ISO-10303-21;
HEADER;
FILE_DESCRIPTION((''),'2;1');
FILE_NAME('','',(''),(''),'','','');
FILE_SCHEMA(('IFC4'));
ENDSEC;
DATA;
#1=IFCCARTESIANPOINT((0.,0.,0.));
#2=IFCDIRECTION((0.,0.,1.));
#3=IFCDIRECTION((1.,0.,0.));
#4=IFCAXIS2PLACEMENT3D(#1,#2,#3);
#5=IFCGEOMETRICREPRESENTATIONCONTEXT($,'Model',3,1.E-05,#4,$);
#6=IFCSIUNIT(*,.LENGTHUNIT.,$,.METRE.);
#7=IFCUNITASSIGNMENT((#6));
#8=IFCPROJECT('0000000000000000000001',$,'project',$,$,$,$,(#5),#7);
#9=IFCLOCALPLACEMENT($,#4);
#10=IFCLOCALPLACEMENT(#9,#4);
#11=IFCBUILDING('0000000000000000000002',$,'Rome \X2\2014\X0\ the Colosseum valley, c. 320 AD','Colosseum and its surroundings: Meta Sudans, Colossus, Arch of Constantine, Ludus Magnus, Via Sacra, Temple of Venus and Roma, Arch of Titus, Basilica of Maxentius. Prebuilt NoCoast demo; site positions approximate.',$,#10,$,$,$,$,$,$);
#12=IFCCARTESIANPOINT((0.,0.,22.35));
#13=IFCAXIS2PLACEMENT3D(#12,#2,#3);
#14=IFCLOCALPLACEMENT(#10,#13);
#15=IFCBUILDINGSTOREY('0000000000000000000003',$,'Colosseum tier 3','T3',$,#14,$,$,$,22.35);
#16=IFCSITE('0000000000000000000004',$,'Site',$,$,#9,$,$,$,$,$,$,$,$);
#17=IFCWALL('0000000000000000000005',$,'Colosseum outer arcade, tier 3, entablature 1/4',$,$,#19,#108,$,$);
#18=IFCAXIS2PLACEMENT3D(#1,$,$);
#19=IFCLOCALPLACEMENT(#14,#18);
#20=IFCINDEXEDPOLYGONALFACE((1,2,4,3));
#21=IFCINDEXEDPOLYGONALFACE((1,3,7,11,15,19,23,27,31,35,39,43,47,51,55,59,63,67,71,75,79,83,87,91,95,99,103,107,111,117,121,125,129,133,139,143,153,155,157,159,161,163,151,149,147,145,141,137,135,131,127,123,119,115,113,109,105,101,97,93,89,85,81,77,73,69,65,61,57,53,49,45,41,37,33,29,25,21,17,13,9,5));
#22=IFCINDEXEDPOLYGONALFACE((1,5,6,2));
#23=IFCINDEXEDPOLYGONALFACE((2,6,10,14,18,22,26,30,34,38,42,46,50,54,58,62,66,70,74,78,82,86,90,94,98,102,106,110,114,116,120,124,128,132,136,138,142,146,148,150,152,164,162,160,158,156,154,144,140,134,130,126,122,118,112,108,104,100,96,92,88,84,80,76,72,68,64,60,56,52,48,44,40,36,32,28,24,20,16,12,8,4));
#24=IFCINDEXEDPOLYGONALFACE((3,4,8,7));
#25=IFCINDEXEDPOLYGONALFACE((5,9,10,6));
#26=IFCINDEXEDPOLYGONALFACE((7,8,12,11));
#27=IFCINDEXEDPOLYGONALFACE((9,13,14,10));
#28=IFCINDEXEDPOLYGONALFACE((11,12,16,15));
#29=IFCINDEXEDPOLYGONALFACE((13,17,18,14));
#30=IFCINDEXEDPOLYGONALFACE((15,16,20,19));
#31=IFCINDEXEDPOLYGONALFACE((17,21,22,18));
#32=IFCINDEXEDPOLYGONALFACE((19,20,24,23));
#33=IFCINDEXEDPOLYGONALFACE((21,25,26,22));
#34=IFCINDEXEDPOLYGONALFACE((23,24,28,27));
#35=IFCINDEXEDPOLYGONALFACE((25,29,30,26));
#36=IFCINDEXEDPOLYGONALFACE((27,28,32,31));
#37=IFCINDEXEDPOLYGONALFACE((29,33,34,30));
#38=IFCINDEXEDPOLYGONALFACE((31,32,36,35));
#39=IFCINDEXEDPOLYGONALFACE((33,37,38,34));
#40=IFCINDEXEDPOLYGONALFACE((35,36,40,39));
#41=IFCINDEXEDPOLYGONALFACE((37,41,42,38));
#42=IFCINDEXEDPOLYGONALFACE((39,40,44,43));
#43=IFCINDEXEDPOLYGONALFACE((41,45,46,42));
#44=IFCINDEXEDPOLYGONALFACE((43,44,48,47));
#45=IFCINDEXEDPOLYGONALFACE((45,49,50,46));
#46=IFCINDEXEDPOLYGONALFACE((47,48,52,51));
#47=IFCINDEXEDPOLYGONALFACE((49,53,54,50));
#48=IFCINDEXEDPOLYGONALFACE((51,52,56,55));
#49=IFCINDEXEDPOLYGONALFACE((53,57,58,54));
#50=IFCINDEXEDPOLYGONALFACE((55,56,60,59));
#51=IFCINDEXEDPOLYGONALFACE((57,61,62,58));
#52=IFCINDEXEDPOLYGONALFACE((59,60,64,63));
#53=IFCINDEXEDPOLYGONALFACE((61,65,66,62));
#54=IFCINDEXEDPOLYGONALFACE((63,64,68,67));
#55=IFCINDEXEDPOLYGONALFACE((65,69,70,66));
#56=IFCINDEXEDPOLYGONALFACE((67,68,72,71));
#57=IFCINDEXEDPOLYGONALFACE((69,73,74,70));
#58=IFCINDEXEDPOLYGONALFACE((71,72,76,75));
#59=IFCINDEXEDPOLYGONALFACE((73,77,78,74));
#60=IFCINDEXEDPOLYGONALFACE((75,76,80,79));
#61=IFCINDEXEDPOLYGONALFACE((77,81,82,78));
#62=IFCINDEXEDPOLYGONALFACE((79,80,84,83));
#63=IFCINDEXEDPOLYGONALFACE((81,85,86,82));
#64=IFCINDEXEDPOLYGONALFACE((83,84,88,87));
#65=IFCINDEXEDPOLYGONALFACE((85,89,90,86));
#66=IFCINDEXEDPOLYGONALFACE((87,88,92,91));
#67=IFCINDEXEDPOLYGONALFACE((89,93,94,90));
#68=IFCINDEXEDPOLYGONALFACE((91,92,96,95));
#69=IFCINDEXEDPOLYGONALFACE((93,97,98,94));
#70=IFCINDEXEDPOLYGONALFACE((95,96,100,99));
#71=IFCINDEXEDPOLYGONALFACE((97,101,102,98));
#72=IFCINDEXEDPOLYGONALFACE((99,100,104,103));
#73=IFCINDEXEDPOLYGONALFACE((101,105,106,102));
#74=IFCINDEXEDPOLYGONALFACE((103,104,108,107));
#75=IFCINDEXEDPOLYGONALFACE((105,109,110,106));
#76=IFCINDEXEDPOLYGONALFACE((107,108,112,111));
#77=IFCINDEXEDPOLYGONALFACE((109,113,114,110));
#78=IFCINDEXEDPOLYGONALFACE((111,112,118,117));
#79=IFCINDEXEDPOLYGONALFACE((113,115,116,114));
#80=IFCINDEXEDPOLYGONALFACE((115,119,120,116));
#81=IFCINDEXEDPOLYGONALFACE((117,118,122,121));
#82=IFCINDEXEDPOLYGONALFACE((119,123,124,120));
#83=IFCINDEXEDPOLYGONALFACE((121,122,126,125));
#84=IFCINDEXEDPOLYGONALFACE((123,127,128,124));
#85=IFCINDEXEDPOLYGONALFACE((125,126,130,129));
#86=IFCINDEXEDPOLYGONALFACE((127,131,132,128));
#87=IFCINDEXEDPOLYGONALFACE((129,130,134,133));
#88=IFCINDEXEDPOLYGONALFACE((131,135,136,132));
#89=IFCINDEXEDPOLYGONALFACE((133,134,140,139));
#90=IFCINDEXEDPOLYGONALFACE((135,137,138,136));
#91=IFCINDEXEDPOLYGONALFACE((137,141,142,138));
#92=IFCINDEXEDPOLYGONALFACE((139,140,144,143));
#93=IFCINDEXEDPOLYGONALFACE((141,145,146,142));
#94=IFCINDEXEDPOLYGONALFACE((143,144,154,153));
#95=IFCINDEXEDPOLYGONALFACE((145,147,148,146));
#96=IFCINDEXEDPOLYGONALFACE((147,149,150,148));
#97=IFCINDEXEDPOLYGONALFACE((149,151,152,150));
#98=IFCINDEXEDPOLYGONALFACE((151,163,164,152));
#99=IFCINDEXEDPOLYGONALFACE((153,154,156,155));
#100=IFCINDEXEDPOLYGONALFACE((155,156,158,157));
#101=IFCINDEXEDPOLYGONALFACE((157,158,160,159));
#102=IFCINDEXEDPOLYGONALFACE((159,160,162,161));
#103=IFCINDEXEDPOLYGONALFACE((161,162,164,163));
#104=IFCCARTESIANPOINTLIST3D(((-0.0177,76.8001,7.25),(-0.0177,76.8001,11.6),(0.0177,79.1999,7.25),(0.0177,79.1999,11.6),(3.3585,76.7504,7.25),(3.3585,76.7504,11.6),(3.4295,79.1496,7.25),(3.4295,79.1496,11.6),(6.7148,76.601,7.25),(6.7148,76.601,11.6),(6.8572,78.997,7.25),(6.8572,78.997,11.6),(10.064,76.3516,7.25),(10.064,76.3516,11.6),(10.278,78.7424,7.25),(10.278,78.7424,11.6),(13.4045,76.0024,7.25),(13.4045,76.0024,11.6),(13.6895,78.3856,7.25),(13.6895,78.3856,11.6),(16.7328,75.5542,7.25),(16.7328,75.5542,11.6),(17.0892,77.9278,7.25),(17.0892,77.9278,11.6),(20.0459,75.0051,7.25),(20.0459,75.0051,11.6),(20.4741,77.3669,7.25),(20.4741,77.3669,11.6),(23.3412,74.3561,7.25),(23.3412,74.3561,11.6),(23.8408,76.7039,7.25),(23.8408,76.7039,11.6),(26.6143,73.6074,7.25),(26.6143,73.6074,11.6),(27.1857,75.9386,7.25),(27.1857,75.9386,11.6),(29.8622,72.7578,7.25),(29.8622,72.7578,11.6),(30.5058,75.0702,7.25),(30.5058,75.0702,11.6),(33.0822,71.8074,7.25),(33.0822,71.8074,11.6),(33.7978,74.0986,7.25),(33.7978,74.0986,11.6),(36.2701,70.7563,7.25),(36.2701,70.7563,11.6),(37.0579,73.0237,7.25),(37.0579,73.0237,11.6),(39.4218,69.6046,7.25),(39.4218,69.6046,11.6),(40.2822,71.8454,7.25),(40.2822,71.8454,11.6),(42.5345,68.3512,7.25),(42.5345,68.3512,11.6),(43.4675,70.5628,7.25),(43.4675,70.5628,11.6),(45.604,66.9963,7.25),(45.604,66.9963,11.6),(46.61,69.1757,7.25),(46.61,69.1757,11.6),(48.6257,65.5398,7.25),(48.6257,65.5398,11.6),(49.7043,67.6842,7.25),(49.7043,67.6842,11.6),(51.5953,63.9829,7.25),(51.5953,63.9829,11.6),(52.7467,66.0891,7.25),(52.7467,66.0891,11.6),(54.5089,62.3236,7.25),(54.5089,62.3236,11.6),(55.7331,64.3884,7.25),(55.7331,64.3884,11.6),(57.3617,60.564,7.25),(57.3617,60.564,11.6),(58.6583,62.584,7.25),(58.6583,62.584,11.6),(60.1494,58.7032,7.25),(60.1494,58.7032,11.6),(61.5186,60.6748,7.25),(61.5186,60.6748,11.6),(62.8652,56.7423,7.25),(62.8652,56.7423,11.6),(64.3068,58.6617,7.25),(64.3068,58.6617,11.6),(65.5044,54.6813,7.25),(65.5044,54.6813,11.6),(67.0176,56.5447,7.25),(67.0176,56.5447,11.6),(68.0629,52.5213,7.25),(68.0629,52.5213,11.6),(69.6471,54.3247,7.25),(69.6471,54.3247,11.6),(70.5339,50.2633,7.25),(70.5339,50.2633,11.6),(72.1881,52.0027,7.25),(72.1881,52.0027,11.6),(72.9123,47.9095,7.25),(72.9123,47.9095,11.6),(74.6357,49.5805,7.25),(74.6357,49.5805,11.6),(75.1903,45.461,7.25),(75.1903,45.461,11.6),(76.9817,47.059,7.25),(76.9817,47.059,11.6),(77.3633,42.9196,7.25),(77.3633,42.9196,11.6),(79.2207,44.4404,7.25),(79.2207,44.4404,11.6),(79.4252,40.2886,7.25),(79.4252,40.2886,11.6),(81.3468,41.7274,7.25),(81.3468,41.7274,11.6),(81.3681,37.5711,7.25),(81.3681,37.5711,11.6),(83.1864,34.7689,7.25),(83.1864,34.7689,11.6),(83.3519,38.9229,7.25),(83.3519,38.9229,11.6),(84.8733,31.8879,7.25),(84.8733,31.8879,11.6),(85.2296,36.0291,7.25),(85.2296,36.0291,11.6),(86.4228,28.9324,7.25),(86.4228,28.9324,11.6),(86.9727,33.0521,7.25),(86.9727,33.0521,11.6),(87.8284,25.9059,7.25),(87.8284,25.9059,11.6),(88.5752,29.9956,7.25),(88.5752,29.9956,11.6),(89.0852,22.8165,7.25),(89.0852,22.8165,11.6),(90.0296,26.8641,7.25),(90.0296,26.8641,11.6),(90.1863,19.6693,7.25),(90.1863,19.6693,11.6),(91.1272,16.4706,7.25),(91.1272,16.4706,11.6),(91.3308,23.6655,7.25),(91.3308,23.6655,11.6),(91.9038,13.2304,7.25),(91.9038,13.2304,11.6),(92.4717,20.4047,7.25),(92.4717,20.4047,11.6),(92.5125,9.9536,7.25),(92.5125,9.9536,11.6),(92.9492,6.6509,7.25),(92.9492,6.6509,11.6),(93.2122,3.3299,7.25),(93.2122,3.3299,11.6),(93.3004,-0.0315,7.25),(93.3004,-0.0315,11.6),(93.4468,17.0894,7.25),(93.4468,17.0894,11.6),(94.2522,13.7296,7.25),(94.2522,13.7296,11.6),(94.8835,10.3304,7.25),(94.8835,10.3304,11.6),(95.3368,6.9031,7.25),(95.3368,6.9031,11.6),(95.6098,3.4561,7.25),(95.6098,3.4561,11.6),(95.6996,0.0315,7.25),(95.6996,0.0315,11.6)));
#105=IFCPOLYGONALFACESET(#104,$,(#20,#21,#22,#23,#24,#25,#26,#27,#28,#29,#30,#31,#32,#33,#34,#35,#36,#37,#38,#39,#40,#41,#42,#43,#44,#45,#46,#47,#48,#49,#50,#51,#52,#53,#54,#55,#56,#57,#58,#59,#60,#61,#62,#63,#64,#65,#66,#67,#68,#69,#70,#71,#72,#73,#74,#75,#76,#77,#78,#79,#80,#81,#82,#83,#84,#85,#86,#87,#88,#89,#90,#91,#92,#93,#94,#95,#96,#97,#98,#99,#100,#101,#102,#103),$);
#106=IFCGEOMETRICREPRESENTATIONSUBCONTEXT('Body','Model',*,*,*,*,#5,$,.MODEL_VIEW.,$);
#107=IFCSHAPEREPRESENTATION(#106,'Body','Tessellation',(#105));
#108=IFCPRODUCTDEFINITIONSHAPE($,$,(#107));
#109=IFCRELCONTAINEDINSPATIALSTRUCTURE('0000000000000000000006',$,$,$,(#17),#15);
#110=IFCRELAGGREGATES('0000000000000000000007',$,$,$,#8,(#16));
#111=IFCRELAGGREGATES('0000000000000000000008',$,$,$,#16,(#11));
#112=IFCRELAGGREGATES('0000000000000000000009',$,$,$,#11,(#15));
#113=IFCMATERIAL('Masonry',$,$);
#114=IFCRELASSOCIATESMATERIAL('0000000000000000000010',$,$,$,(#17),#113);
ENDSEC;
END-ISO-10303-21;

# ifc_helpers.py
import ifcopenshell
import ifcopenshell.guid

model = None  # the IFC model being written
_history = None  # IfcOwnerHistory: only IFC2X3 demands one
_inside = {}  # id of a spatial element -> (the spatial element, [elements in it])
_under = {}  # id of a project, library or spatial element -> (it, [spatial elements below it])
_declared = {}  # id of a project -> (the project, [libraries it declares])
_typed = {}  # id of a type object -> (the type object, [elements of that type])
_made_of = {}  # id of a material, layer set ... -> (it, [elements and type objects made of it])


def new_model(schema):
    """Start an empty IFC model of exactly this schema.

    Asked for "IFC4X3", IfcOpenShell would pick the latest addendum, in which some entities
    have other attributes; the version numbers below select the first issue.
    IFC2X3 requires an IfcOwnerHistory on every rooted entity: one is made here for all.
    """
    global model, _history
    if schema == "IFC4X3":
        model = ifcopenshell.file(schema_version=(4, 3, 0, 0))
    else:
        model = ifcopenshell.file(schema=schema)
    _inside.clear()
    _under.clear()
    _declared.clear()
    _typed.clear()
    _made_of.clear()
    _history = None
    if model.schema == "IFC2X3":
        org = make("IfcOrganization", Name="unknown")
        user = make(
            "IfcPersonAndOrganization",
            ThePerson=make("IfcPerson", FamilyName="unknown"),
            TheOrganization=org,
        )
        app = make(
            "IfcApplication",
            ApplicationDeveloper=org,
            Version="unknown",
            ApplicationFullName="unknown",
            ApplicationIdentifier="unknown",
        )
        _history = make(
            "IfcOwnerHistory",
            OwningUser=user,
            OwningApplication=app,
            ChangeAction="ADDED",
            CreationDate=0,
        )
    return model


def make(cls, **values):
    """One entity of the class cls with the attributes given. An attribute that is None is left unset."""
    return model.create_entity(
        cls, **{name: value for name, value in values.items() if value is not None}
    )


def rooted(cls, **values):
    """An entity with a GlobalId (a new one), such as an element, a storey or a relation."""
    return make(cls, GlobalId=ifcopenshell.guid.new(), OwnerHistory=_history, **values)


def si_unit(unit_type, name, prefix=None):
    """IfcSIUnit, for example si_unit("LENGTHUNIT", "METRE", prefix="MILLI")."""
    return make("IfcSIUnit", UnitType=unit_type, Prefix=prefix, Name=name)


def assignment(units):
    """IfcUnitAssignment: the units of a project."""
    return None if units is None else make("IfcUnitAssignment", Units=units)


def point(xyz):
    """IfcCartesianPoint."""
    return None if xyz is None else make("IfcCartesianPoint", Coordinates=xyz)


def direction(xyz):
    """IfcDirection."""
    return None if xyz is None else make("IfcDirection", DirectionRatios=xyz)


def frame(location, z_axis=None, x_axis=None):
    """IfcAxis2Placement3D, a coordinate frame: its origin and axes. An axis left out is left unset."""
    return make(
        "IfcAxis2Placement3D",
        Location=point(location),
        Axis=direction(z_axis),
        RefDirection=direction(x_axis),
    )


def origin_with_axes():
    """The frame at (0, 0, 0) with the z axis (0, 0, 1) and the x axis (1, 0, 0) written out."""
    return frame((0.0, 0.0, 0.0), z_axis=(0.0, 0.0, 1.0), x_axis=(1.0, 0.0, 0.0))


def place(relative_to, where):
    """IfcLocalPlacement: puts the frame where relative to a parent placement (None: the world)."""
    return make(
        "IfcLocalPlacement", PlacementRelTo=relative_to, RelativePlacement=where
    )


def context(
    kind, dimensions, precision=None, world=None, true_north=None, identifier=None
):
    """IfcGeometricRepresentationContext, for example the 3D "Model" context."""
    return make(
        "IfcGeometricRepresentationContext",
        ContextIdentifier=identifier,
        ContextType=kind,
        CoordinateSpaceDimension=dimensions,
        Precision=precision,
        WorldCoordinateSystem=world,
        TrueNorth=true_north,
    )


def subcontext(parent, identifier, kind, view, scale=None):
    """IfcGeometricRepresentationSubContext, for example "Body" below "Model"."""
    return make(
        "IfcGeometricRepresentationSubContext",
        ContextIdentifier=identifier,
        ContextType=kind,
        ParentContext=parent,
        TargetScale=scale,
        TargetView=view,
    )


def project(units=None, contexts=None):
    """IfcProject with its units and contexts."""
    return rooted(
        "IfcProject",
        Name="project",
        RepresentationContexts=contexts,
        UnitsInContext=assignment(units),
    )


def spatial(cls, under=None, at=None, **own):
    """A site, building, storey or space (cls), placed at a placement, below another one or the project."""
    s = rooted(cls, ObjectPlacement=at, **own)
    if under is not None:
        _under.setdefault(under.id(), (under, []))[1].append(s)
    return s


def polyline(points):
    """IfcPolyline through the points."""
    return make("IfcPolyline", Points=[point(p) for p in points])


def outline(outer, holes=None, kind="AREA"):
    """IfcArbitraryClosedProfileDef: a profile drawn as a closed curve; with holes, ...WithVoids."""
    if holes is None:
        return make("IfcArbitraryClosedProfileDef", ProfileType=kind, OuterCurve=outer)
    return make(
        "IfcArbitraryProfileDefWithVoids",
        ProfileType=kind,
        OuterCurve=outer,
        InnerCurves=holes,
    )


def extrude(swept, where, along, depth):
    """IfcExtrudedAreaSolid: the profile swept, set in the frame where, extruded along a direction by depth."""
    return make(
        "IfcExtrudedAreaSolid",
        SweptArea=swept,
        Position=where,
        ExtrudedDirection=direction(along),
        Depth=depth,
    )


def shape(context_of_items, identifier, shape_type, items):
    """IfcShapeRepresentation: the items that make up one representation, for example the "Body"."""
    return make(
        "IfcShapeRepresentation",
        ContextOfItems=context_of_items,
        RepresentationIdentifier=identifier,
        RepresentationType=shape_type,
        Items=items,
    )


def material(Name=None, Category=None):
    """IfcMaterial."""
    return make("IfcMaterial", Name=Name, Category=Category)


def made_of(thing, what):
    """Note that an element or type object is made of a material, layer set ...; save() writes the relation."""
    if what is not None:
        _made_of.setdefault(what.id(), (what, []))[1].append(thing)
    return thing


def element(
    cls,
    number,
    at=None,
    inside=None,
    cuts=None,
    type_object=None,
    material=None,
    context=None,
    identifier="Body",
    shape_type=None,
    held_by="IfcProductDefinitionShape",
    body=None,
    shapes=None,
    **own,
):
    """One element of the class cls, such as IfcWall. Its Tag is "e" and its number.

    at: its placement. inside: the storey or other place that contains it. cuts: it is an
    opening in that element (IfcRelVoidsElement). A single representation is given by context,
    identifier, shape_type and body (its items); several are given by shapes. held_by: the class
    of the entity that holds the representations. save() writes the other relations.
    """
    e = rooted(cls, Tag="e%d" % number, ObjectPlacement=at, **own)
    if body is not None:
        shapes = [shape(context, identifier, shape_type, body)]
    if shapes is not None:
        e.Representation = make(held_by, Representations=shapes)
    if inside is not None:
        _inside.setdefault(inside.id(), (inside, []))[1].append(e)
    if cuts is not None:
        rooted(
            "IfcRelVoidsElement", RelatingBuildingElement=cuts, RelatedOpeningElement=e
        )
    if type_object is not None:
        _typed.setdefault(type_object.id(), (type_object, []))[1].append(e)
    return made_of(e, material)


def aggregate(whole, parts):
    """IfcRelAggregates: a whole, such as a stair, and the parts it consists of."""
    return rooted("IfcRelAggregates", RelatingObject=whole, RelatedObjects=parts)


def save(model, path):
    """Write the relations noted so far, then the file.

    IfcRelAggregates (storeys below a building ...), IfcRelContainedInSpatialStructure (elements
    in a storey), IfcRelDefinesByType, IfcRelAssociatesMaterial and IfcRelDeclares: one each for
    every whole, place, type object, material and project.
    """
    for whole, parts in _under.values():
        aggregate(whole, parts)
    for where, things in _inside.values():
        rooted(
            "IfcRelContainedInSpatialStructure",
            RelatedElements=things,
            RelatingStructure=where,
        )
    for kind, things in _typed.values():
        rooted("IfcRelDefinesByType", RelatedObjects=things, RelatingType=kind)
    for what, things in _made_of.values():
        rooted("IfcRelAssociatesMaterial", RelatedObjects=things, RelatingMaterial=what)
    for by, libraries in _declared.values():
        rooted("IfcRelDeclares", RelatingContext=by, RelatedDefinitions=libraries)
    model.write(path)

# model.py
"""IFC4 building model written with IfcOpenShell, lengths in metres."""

from ifc_helpers import new_model, si_unit, frame, origin_with_axes, place, context, subcontext, project, spatial, polyline, outline, extrude, material, element, save


model = new_model("IFC4")

# Units and contexts
model_context = context("Model", 3, precision=1e-05, world=origin_with_axes())
body_context = subcontext(model_context, "Body", "Model", "MODEL_VIEW")
ifc_project = project(units=[si_unit("LENGTHUNIT", "METRE")], contexts=[model_context])

# Site, building, storey
site_placement = place(None, origin_with_axes())
site = spatial("IfcSite", under=ifc_project, at=site_placement, Name="Site")
building_placement = place(site_placement, origin_with_axes())
building = spatial("IfcBuilding", under=site, at=building_placement, Name="Rome — the Colosseum valley, c. 320 AD", Description="Colosseum and its surroundings: Meta Sudans, Colossus, Arch of Constantine, Ludus Magnus, Via Sacra, Temple of Venus and Roma, Arch of Titus, Basilica of Maxentius. Prebuilt NoCoast demo; site positions approximate.")
storey_placement = place(building_placement, frame((0.0, 0.0, 22.35), z_axis=(0.0, 0.0, 1.0), x_axis=(1.0, 0.0, 0.0)))
storey = spatial("IfcBuildingStorey", under=building, at=storey_placement, Name="Colosseum tier 3", Description="T3", Elevation=22.35)

# Wall
ifc_material_1 = material(Name="Masonry")
wall_1_placement = place(storey_placement, frame((0.0, 0.0, 7.25), z_axis=(0.0, 0.0, 1.0), x_axis=(1.0, 0.0, 0.0)))
element("IfcWall", 1, at=wall_1_placement, inside=storey, material=ifc_material_1, Name="Colosseum outer arcade, tier 3, entablature 1/4", context=body_context, shape_type="SweptSolid", body=[
    extrude(outline(polyline([(93.2122, 3.3299), (92.9492, 6.6509), (92.5125, 9.9536), (91.9038, 13.2304), (91.1272, 16.4706), (90.1863, 19.6693), (89.0852, 22.8165), (87.8284, 25.9059), (86.4228, 28.9324), (84.8733, 31.8879), (83.1864, 34.7689), (81.3681, 37.5711), (79.4252, 40.2886), (77.3633, 42.9196), (75.1903, 45.461), (72.9123, 47.9095), (70.5339, 50.2633), (68.0629, 52.5213), (65.5044, 54.6813), (62.8652, 56.7423), (60.1494, 58.7032), (57.3617, 60.564), (54.5089, 62.3236), (51.5953, 63.9829), (48.6257, 65.5398), (45.604, 66.9963), (42.5345, 68.3512), (39.4218, 69.6046), (36.2701, 70.7563), (33.0822, 71.8074), (29.8622, 72.7578), (26.6143, 73.6074), (23.3412, 74.3561), (20.0459, 75.0051), (16.7328, 75.5542), (13.4045, 76.0024), (10.064, 76.3516), (6.7148, 76.601), (3.3585, 76.7504), (-0.0177, 76.8001), (0.0177, 79.1999), (3.4295, 79.1496), (6.8572, 78.997), (10.278, 78.7424), (13.6895, 78.3856), (17.0892, 77.9278), (20.4741, 77.3669), (23.8408, 76.7039), (27.1857, 75.9386), (30.5058, 75.0702), (33.7978, 74.0986), (37.0579, 73.0237), (40.2822, 71.8454), (43.4675, 70.5628), (46.61, 69.1757), (49.7043, 67.6842), (52.7467, 66.0891), (55.7331, 64.3884), (58.6583, 62.584), (61.5186, 60.6748), (64.3068, 58.6617), (67.0176, 56.5447), (69.6471, 54.3247), (72.1881, 52.0027), (74.6357, 49.5805), (76.9817, 47.059), (79.2207, 44.4404), (81.3468, 41.7274), (83.3519, 38.9229), (85.2296, 36.0291), (86.9727, 33.0521), (88.5752, 29.9956), (90.0296, 26.8641), (91.3308, 23.6655), (92.4717, 20.4047), (93.4468, 17.0894), (94.2522, 13.7296), (94.8835, 10.3304), (95.3368, 6.9031), (95.6098, 3.4561), (95.6996, 0.0315), (93.3004, -0.0315), (93.2122, 3.3299)])), origin_with_axes(), (0.0, 0.0, 1.0), 4.35),
])

save(model, "model.ifc")
